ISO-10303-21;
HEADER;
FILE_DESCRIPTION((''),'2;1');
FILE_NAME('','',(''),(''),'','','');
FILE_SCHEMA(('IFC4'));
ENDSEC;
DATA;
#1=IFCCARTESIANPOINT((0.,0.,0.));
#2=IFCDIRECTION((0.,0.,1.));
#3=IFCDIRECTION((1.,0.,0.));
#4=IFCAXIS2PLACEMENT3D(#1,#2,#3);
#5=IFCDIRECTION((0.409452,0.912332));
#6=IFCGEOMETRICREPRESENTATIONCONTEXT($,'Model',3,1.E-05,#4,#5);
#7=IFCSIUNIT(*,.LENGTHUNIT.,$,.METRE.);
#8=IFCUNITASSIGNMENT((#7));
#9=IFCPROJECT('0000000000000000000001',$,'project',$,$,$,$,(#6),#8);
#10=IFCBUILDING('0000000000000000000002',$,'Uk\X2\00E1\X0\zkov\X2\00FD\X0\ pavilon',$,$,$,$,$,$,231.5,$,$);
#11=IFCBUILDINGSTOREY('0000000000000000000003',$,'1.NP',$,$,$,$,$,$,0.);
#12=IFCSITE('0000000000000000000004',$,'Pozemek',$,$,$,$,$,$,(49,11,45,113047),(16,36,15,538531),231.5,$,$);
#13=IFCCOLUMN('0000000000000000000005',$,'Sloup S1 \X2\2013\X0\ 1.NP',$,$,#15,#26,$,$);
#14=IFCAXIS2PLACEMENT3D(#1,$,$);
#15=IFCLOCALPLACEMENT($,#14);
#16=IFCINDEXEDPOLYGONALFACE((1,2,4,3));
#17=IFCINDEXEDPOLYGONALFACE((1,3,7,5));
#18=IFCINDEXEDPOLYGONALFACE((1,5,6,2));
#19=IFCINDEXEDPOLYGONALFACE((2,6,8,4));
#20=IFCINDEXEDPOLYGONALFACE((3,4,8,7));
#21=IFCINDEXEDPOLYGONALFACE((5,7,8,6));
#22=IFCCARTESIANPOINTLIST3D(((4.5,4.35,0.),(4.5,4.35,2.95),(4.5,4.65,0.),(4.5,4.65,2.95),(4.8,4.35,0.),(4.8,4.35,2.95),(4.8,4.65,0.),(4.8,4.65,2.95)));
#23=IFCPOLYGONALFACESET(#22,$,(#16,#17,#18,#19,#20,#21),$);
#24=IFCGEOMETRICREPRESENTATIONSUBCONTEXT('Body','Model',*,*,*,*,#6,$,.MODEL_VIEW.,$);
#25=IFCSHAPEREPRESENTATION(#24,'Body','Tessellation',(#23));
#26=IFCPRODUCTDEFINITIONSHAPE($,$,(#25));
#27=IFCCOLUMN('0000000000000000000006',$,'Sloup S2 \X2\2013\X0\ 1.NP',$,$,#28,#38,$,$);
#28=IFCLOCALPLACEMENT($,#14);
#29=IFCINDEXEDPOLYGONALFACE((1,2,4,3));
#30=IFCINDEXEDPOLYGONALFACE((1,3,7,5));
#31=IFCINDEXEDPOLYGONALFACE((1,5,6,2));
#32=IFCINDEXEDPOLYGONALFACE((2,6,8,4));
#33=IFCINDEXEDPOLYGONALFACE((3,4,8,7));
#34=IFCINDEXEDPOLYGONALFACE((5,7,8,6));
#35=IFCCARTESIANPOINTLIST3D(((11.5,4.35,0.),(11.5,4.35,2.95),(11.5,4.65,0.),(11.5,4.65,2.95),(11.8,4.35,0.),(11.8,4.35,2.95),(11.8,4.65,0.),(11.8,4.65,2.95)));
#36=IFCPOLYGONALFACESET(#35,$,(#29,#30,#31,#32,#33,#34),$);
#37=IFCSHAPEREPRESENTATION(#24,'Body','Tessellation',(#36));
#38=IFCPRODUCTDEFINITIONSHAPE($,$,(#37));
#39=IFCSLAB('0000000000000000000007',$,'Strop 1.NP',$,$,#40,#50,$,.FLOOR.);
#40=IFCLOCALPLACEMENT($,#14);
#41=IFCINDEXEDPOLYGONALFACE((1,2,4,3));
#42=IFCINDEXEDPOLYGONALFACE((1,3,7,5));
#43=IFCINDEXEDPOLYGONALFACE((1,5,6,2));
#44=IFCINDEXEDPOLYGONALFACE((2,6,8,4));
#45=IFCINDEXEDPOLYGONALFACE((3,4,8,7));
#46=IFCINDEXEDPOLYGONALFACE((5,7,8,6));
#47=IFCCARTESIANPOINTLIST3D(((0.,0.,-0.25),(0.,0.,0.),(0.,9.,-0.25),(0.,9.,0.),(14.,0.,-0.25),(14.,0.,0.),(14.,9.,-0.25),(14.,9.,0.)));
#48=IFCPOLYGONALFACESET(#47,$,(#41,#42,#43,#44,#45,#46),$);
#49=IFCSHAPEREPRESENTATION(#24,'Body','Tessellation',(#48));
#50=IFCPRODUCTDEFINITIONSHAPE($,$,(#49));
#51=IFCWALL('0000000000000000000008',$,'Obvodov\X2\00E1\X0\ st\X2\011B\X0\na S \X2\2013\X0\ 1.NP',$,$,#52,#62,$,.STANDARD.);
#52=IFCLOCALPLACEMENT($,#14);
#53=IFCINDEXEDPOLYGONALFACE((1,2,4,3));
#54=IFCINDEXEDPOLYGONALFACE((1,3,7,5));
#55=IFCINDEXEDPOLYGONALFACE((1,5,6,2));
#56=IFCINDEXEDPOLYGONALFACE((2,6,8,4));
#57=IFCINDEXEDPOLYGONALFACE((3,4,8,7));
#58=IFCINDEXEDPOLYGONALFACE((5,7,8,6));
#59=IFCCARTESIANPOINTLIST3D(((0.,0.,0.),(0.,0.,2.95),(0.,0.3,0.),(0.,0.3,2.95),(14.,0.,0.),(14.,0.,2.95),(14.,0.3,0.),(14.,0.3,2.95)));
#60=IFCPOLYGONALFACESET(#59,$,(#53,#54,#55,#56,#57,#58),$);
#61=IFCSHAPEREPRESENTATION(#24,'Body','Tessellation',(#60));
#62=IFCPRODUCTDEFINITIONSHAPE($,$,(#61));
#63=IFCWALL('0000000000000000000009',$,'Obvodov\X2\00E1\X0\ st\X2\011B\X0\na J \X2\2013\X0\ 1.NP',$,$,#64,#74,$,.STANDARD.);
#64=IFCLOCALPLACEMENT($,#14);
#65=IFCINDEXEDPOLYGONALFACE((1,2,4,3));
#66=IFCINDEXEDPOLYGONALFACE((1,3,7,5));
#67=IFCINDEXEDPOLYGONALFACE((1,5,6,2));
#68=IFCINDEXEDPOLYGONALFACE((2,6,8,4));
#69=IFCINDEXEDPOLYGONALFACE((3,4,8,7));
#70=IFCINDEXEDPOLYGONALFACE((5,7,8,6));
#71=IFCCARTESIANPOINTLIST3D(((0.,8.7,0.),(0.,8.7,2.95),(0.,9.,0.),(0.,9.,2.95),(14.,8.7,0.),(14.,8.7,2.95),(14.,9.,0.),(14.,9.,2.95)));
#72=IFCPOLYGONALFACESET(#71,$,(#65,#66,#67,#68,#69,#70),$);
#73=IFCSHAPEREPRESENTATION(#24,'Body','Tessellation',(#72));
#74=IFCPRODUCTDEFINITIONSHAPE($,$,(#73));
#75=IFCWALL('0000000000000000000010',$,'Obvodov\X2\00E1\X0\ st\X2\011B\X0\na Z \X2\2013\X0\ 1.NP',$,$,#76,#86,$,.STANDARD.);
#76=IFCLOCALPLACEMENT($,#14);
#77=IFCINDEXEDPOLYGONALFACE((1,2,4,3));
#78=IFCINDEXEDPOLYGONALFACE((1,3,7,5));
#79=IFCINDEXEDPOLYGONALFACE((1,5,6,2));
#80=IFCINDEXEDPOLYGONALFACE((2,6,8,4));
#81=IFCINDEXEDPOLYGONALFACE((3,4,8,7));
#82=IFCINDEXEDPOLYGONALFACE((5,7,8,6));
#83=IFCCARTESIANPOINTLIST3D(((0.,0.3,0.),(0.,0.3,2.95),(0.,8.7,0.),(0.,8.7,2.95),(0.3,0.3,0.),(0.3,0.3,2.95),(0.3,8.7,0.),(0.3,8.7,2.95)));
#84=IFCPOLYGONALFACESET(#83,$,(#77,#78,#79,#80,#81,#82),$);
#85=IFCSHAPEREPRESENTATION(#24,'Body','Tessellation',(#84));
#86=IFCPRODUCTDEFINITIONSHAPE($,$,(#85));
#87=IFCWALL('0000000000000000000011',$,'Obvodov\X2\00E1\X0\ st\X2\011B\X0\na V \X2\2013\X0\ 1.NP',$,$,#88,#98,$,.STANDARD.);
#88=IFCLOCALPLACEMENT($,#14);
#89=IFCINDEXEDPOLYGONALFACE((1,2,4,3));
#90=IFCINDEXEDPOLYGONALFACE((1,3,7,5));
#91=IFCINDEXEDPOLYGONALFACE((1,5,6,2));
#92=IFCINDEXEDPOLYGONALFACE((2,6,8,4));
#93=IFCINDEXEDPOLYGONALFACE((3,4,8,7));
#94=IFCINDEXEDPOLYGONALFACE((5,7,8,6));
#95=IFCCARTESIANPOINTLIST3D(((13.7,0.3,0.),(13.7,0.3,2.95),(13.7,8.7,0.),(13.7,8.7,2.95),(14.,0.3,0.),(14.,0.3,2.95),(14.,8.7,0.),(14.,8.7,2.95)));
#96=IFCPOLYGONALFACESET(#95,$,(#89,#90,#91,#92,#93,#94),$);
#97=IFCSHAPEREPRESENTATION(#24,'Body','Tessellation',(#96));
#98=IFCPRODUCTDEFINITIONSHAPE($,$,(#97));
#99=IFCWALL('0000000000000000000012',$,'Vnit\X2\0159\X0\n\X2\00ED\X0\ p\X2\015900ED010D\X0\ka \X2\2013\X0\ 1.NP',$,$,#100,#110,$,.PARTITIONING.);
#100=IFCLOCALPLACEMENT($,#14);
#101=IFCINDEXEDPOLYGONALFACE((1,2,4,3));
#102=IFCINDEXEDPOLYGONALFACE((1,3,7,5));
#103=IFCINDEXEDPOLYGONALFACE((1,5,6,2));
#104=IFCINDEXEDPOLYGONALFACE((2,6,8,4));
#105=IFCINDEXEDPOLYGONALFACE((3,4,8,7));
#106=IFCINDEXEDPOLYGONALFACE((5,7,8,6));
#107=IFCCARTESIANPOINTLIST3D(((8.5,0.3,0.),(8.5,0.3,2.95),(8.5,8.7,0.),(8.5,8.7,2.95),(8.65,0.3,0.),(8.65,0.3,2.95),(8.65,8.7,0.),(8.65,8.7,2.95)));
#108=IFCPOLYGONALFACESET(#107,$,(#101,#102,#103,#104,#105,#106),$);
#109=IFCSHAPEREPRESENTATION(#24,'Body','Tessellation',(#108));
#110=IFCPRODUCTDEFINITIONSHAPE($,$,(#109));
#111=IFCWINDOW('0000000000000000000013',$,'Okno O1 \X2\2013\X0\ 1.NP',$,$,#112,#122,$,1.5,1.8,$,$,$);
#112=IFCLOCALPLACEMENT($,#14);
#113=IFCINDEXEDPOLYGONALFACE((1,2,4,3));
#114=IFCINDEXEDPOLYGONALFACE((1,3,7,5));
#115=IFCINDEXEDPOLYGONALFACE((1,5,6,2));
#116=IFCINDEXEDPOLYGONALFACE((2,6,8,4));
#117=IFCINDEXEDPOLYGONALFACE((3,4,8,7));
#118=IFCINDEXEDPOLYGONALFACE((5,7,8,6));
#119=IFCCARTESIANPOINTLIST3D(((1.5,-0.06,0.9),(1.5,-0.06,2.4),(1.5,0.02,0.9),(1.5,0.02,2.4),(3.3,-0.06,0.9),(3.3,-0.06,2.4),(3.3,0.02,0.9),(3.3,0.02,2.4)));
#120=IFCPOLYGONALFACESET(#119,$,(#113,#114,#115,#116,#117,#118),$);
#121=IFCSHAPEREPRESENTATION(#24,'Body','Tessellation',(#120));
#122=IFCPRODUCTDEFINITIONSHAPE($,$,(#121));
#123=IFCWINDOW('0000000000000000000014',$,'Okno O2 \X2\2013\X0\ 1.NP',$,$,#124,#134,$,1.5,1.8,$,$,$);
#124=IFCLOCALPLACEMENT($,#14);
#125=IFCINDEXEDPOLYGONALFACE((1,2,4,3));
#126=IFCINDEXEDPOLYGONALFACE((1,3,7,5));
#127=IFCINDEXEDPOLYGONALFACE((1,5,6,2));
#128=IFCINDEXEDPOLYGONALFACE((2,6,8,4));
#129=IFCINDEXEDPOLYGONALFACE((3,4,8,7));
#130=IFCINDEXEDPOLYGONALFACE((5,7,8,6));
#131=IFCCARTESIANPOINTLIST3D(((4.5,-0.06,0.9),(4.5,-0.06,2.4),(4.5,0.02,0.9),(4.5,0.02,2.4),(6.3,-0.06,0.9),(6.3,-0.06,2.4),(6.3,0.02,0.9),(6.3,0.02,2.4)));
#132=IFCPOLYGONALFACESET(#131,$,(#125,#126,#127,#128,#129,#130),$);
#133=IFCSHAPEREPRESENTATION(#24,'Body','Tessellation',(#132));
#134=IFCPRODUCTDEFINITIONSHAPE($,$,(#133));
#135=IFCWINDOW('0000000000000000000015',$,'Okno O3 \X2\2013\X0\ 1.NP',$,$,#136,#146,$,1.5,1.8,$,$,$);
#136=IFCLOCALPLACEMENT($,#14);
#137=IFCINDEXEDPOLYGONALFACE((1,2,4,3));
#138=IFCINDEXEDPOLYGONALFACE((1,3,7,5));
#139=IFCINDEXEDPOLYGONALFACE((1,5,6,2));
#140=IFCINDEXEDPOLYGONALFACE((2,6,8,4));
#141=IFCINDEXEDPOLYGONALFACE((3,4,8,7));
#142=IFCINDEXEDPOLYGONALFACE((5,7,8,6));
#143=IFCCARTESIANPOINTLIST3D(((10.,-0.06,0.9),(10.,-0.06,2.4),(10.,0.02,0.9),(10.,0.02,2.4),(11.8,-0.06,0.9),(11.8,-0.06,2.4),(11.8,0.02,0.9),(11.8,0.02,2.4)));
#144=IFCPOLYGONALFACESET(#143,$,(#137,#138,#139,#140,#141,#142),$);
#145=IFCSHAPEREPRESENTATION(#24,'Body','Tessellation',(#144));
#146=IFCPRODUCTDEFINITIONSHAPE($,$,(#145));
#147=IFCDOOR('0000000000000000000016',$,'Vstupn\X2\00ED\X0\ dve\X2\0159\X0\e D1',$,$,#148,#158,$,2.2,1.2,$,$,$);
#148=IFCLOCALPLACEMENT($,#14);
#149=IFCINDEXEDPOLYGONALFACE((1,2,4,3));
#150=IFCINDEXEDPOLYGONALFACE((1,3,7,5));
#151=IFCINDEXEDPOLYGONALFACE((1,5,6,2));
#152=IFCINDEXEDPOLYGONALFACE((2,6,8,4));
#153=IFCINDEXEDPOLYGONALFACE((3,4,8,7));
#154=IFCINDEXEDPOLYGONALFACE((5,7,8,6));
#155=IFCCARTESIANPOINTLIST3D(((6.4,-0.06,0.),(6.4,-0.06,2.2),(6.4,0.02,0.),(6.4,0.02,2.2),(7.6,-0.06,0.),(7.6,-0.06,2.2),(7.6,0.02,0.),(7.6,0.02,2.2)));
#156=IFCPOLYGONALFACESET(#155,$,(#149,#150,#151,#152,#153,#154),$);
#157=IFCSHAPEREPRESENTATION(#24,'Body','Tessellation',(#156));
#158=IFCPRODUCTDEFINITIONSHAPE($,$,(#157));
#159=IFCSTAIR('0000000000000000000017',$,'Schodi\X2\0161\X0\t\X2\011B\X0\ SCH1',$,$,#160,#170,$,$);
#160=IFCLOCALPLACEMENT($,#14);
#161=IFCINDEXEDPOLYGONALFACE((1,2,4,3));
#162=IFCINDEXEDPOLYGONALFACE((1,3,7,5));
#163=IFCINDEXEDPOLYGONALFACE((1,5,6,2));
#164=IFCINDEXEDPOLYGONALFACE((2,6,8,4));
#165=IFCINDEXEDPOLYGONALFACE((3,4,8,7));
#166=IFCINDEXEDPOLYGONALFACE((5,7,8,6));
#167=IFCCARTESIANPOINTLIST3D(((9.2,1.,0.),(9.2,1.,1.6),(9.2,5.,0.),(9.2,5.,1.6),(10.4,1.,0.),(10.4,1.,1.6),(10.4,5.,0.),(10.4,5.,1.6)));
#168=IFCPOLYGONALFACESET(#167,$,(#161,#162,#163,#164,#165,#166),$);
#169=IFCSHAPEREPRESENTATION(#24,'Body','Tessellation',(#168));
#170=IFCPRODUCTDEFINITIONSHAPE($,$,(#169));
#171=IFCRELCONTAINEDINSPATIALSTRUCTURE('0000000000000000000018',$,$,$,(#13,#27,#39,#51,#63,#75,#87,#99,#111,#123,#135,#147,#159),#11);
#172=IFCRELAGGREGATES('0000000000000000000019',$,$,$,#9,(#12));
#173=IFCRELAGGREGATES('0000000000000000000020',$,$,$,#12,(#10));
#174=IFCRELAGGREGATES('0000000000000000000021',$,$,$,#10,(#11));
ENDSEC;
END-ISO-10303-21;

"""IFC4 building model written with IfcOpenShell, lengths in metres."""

from ifc_helpers import new_model, si_unit, direction, frame, frame_2d, origin, origin_with_axes, place, context, subcontext, project, spatial, rectangle, extrude, element, save


model = new_model("IFC4")

# Units and contexts
model_context = context("Model", 3, precision=1e-05, world=origin_with_axes(), true_north=direction((0.409452, 0.912332)))
body_context = subcontext(model_context, "Body", "Model", "MODEL_VIEW")
ifc_project = project(units=[si_unit("LENGTHUNIT", "METRE")], contexts=[model_context])

# Site, building, storey
site = spatial("IfcSite", under=ifc_project, Name="Pozemek", RefLatitude=(49, 11, 45, 113047), RefLongitude=(16, 36, 15, 538531), RefElevation=231.5)
building = spatial("IfcBuilding", under=site, Name="Ukázkový pavilon", ElevationOfRefHeight=231.5)
storey = spatial("IfcBuildingStorey", under=building, Name="1.NP", Elevation=0.0)

# Columns
for number, where, z_axis, x_axis, name in (
    (1, (4.5, 4.35, 0.0), (0.0, 0.0, 1.0), (1.0, 0.0, 0.0), "Sloup S1 – 1.NP"),
    (2, (11.5, 4.35, 0.0), (0.0, 0.0, 1.0), (1.0, 0.0, 0.0), "Sloup S2 – 1.NP"),
):
    element("IfcColumn", number, at=place(None, frame(where, z_axis=z_axis, x_axis=x_axis)), inside=storey, Name=name, context=body_context, shape_type="SweptSolid", body=[
        extrude(rectangle(XDim=0.3, YDim=0.3, at=frame_2d((0.15, 0.15))), origin(), (0.0, 0.0, 1.0), 2.95),
    ])

# Slab
slab_placement = place(None, frame((0.0, 0.0, -0.25), z_axis=(0.0, 0.0, 1.0), x_axis=(1.0, 0.0, 0.0)))
element("IfcSlab", 3, at=slab_placement, inside=storey, Name="Strop 1.NP", PredefinedType="FLOOR", context=body_context, shape_type="SweptSolid", body=[
    extrude(rectangle(XDim=14.0, YDim=9.0, at=frame_2d((7.0, 4.5))), origin(), (0.0, 0.0, 1.0), 0.25),
])

# Walls
for number, where, z_axis, x_axis, name in (
    (4, (0.0, 0.0, 0.0), (0.0, 0.0, 1.0), (1.0, 0.0, 0.0), "Obvodová stěna S – 1.NP"),
    (5, (0.0, 8.7, 0.0), (0.0, 0.0, 1.0), (1.0, 0.0, 0.0), "Obvodová stěna J – 1.NP"),
):
    element("IfcWall", number, at=place(None, frame(where, z_axis=z_axis, x_axis=x_axis)), inside=storey, Name=name, PredefinedType="STANDARD", context=body_context, shape_type="SweptSolid", body=[
        extrude(rectangle(XDim=14.0, YDim=0.3, at=frame_2d((7.0, 0.15))), origin(), (0.0, 0.0, 1.0), 2.95),
    ])
for number, where, z_axis, x_axis, name in (
    (6, (0.0, 0.3, 0.0), (0.0, 0.0, 1.0), (1.0, 0.0, 0.0), "Obvodová stěna Z – 1.NP"),
    (7, (13.7, 0.3, 0.0), (0.0, 0.0, 1.0), (1.0, 0.0, 0.0), "Obvodová stěna V – 1.NP"),
):
    element("IfcWall", number, at=place(None, frame(where, z_axis=z_axis, x_axis=x_axis)), inside=storey, Name=name, PredefinedType="STANDARD", context=body_context, shape_type="SweptSolid", body=[
        extrude(rectangle(XDim=0.3, YDim=8.4, at=frame_2d((0.15, 4.2))), origin(), (0.0, 0.0, 1.0), 2.95),
    ])
wall_placement = place(None, frame((8.5, 0.3, 0.0), z_axis=(0.0, 0.0, 1.0), x_axis=(1.0, 0.0, 0.0)))
element("IfcWall", 8, at=wall_placement, inside=storey, Name="Vnitřní příčka – 1.NP", PredefinedType="PARTITIONING", context=body_context, shape_type="SweptSolid", body=[
    extrude(rectangle(XDim=0.15, YDim=8.4, at=frame_2d((0.075, 4.2))), origin(), (0.0, 0.0, 1.0), 2.95),
])

# Windows
for number, where, z_axis, x_axis, name in (
    (9, (1.5, -0.06, 0.9), (0.0, 0.0, 1.0), (1.0, 0.0, 0.0), "Okno O1 – 1.NP"),
    (10, (4.5, -0.06, 0.9), (0.0, 0.0, 1.0), (1.0, 0.0, 0.0), "Okno O2 – 1.NP"),
    (11, (10.0, -0.06, 0.9), (0.0, 0.0, 1.0), (1.0, 0.0, 0.0), "Okno O3 – 1.NP"),
):
    element("IfcWindow", number, at=place(None, frame(where, z_axis=z_axis, x_axis=x_axis)), inside=storey, Name=name, OverallHeight=1.5, OverallWidth=1.8, context=body_context, shape_type="SweptSolid", body=[
        extrude(rectangle(XDim=1.8, YDim=0.08, at=frame_2d((0.9, 0.04))), origin(), (0.0, 0.0, 1.0), 1.5),
    ])

# Door
door_placement = place(None, frame((6.4, -0.06, 0.0), z_axis=(0.0, 0.0, 1.0), x_axis=(1.0, 0.0, 0.0)))
element("IfcDoor", 12, at=door_placement, inside=storey, Name="Vstupní dveře D1", OverallHeight=2.2, OverallWidth=1.2, context=body_context, shape_type="SweptSolid", body=[
    extrude(rectangle(XDim=1.2, YDim=0.08, at=frame_2d((0.6, 0.04))), origin(), (0.0, 0.0, 1.0), 2.2),
])

# Stair
stair_placement = place(None, frame((9.2, 1.0, 0.0), z_axis=(0.0, 0.0, 1.0), x_axis=(1.0, 0.0, 0.0)))
element("IfcStair", 13, at=stair_placement, inside=storey, Name="Schodiště SCH1", context=body_context, shape_type="SweptSolid", body=[
    extrude(rectangle(XDim=1.2, YDim=4.0, at=frame_2d((0.6, 2.0))), origin(), (0.0, 0.0, 1.0), 1.6),
])

save(model, "model.ifc")
